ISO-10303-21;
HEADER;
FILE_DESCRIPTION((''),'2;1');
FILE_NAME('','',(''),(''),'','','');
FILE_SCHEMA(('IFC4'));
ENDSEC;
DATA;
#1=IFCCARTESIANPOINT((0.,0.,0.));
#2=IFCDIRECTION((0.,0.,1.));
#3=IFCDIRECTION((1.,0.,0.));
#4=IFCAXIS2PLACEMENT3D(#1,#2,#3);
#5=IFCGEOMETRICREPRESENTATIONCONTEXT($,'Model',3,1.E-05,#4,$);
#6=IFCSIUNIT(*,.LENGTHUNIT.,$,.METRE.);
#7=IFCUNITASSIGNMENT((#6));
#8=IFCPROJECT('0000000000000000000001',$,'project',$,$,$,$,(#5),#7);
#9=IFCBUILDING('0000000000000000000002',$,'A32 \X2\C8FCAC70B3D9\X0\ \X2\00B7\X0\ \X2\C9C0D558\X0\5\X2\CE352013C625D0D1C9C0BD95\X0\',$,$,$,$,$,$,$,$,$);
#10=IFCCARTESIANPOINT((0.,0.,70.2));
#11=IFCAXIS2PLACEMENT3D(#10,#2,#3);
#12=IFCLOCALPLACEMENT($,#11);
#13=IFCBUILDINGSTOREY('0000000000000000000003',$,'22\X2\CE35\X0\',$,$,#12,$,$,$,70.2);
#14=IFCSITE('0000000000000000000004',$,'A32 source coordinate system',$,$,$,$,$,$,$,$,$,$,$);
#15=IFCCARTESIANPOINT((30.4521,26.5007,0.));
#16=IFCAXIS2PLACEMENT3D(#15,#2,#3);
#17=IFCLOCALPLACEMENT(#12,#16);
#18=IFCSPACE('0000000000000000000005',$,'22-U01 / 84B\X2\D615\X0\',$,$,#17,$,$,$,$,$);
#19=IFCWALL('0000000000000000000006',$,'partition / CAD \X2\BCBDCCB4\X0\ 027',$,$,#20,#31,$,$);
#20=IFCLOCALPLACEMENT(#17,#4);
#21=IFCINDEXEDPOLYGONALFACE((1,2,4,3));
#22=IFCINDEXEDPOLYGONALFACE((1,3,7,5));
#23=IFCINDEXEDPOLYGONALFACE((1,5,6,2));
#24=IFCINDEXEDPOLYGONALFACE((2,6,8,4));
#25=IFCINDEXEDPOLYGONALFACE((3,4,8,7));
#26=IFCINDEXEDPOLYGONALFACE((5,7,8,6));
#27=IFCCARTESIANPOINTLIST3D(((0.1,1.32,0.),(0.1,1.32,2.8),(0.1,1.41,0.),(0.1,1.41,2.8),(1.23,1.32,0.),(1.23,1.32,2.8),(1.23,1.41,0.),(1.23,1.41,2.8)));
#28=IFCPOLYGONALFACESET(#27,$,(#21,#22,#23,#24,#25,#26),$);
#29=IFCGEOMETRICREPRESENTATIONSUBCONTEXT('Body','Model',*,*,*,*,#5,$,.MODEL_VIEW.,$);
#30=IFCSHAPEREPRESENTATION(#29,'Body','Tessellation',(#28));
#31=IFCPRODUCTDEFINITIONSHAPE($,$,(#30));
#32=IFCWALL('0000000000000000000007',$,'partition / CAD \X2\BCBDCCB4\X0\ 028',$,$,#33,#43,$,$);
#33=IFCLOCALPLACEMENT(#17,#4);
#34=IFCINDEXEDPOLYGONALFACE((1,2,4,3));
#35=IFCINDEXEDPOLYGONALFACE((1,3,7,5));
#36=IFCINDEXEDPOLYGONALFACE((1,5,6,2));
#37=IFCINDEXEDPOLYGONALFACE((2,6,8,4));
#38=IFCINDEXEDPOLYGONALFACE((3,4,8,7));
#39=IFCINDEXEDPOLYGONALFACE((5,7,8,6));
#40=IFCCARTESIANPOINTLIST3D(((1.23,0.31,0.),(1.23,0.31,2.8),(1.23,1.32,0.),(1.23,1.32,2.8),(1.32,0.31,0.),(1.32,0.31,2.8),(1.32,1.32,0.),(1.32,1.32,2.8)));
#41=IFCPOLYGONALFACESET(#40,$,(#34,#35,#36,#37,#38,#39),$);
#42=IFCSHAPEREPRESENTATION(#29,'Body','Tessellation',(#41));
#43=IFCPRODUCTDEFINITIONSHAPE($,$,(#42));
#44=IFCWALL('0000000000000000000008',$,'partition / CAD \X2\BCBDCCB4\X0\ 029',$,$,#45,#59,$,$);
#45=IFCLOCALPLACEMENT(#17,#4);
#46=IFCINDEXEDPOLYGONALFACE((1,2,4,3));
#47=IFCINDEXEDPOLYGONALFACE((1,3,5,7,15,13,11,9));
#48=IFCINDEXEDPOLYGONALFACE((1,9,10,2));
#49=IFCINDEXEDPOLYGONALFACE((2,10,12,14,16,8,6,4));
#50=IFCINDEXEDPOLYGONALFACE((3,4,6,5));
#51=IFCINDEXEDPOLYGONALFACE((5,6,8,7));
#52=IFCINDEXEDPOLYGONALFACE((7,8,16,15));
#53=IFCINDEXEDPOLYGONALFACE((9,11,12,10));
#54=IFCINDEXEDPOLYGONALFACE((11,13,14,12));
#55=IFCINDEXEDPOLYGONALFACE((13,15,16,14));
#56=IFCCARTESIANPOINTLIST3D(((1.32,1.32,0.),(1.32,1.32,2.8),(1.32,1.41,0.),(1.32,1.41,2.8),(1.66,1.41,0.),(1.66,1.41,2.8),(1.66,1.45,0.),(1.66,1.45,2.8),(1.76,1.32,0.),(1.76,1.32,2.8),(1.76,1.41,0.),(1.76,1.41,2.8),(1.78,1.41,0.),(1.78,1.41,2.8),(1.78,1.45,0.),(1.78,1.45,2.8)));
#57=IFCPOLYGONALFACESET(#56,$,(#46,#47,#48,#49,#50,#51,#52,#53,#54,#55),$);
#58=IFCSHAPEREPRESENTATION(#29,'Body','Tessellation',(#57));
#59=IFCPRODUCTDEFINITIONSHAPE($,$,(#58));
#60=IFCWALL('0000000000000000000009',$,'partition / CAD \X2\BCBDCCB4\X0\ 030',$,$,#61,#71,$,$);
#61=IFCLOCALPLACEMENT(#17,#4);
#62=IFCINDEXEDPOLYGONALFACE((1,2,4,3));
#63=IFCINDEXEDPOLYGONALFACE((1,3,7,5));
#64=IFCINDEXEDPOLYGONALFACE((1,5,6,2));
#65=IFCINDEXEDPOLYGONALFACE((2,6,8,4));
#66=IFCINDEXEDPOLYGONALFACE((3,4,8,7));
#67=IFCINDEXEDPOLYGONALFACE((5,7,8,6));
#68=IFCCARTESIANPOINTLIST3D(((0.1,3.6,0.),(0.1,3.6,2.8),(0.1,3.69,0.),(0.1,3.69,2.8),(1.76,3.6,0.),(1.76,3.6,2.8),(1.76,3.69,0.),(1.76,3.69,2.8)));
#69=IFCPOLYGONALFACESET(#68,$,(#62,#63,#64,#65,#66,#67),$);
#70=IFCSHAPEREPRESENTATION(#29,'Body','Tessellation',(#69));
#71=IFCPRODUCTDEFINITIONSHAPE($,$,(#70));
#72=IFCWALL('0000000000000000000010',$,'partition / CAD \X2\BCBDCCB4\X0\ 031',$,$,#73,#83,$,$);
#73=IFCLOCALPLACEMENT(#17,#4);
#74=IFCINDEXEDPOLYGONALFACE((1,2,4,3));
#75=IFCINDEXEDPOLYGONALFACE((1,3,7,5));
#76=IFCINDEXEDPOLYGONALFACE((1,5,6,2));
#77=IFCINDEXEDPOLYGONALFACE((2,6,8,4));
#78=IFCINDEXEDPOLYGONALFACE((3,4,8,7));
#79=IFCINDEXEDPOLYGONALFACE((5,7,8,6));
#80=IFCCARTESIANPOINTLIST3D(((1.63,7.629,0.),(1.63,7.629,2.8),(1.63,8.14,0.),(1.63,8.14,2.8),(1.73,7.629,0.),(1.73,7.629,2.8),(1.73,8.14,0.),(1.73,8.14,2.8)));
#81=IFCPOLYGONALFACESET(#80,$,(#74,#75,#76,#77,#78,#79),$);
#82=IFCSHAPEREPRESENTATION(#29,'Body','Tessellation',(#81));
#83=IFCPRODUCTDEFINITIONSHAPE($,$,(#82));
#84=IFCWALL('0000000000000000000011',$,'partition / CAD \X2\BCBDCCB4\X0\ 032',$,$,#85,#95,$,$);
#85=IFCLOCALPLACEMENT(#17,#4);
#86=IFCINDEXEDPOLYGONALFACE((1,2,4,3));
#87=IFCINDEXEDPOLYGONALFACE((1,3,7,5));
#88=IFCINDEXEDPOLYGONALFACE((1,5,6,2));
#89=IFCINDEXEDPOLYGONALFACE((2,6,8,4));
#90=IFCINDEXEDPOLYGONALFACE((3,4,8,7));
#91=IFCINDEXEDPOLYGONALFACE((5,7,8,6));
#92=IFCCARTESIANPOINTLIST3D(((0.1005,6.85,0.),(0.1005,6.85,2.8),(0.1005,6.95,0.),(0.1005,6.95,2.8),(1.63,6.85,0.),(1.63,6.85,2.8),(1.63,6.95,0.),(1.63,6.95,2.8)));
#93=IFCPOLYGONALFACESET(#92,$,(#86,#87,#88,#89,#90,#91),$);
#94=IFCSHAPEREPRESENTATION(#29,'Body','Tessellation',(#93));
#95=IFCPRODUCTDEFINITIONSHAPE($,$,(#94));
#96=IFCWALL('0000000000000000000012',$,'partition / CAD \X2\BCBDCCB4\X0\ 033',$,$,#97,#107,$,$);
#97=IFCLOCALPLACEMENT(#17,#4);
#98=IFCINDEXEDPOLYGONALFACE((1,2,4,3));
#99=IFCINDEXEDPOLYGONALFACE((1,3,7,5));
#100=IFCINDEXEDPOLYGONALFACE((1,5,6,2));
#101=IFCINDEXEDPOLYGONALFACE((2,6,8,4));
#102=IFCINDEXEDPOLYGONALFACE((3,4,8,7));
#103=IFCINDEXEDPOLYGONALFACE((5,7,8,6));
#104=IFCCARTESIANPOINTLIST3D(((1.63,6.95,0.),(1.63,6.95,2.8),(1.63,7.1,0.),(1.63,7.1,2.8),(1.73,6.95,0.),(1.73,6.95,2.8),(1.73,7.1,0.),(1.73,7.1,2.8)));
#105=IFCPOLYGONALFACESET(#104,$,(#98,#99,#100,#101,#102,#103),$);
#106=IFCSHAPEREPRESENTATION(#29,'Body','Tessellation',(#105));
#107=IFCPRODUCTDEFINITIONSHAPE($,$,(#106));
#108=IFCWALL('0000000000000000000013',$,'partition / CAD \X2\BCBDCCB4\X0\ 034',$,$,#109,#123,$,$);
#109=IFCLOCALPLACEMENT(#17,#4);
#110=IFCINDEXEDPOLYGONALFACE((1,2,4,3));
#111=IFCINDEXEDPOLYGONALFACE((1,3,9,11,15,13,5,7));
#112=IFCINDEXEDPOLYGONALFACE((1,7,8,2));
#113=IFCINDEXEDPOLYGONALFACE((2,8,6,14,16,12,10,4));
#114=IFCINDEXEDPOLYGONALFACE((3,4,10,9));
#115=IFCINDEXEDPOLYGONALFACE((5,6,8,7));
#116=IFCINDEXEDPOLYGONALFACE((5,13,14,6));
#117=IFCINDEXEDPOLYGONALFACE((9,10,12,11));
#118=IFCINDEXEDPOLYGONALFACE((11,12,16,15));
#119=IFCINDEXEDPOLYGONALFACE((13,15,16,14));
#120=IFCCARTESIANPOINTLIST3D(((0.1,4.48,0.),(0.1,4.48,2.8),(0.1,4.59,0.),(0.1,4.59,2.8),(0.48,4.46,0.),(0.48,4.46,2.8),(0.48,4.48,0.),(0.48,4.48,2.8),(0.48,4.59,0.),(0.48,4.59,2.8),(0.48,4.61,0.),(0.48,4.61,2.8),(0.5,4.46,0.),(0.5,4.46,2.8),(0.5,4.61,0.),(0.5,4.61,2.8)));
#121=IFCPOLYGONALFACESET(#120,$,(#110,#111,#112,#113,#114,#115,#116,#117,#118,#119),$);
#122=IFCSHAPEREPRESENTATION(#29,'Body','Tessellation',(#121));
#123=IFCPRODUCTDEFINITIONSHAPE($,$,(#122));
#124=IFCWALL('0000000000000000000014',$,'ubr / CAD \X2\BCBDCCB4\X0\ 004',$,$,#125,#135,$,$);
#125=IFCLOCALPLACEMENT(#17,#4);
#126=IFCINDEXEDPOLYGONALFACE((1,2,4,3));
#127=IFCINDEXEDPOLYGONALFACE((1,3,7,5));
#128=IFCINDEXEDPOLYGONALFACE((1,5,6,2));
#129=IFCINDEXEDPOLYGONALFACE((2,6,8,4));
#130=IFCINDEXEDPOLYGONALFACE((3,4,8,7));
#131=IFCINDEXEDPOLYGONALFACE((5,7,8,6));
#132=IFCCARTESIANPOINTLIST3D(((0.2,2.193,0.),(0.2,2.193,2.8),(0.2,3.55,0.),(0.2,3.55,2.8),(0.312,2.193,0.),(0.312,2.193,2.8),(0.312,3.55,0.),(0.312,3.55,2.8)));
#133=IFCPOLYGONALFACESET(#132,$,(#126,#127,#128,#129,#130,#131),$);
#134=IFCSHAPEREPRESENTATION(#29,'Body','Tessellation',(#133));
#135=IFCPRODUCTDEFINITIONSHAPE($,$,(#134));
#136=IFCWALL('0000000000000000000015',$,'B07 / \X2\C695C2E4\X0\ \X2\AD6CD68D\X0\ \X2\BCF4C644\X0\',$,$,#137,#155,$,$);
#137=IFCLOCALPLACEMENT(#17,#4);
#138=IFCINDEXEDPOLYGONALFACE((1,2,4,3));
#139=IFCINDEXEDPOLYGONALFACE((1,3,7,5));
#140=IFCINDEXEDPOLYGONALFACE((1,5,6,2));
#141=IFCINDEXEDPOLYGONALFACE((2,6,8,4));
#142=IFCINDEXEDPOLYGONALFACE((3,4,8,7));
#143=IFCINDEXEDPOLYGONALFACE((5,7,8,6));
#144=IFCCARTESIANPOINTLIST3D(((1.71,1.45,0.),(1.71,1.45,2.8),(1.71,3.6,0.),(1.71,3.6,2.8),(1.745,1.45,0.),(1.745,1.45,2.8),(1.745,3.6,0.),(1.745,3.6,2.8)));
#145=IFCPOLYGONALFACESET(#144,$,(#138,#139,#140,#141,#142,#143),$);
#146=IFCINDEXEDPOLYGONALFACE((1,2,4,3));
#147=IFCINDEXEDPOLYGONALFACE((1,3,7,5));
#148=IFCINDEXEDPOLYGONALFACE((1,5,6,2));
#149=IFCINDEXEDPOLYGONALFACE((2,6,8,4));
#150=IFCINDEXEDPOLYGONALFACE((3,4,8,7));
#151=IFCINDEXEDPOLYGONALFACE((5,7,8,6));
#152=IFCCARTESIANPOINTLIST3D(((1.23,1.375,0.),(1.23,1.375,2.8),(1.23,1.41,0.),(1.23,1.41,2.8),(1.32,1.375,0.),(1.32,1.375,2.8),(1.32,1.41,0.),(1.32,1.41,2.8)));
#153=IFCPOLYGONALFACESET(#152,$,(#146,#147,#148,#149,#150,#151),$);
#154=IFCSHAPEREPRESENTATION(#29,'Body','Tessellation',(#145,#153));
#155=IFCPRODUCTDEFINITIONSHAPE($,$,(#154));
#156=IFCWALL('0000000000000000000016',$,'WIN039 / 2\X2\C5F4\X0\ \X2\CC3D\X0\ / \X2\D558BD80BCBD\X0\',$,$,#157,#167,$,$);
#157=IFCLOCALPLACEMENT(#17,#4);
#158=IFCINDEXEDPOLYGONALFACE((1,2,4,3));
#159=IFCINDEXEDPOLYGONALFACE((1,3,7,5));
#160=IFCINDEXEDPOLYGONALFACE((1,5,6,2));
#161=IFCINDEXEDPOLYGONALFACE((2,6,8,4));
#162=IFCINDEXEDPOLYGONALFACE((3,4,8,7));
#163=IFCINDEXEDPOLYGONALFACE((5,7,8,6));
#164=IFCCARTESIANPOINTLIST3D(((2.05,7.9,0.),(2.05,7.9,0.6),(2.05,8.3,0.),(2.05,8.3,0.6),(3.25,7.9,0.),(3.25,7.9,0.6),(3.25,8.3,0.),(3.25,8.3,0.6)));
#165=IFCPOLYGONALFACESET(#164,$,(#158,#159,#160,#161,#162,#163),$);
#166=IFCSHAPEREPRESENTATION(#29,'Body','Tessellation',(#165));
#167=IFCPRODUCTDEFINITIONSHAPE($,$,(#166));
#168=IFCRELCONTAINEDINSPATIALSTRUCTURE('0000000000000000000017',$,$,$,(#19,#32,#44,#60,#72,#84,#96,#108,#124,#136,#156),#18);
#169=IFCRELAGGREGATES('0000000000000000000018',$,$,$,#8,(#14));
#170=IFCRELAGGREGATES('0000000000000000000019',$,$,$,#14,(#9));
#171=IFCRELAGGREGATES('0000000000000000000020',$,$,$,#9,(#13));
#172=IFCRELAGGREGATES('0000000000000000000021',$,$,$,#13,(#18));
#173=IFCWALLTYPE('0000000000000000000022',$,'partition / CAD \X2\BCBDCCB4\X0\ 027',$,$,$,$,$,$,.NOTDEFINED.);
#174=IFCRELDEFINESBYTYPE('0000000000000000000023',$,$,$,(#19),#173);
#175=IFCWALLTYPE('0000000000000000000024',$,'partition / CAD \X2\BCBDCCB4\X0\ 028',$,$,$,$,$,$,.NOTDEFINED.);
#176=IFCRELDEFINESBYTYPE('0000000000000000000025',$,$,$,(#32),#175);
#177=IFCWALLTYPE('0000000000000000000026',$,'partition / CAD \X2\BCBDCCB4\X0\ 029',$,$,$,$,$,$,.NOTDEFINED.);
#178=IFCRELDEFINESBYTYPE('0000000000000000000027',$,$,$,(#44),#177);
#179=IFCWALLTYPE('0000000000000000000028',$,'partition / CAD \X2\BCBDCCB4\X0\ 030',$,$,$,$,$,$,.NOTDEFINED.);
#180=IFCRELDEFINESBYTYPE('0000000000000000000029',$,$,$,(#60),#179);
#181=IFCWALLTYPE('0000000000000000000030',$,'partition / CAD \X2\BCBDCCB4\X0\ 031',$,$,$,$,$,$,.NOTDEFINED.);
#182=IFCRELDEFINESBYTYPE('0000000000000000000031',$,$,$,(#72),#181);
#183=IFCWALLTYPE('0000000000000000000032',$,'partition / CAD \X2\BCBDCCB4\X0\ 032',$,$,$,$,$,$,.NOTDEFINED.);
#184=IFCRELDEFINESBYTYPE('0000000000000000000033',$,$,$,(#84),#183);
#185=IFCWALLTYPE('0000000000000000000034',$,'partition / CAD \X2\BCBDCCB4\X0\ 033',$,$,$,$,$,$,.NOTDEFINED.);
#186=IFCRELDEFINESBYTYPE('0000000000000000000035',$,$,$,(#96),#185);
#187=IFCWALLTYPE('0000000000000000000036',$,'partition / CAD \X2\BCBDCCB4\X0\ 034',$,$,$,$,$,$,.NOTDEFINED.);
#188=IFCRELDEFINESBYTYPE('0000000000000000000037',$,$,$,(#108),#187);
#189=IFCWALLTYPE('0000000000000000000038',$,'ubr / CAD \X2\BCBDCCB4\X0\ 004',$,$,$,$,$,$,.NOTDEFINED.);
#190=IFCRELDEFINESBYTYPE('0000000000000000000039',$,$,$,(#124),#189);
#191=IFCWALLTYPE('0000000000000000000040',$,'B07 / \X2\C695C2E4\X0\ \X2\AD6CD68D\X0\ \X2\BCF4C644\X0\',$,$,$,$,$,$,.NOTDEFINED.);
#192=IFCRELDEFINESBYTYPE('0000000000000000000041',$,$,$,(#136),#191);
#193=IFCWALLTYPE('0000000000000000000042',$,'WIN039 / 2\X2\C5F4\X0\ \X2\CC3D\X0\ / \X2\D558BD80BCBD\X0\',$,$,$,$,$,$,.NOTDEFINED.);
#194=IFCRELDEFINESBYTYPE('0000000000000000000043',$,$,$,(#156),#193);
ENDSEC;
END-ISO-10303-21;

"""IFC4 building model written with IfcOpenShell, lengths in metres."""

from ifc_helpers import new_model, si_unit, frame, origin, origin_with_axes, place, context, subcontext, project, spatial, polyline, outline, extrude, source, transform, mapped, type_object, type_shapes, element, save


model = new_model("IFC4")

# Units and contexts
model_context = context("Model", 3, precision=1e-05, world=origin_with_axes())
body_context = subcontext(model_context, "Body", "Model", "MODEL_VIEW")
ifc_project = project(units=[si_unit("LENGTHUNIT", "METRE")], contexts=[model_context])

# Site, building, storey, space
site = spatial("IfcSite", under=ifc_project, Name="A32 source coordinate system")
building = spatial("IfcBuilding", under=site, Name="A32 주거동 · 지하5층–옥탑지붕")
storey_placement = place(None, frame((0.0, 0.0, 70.2), z_axis=(0.0, 0.0, 1.0), x_axis=(1.0, 0.0, 0.0)))
storey = spatial("IfcBuildingStorey", under=building, at=storey_placement, Name="22층", Elevation=70.2)
space_placement = place(storey_placement, frame((30.4521, 26.5007, 0.0), z_axis=(0.0, 0.0, 1.0), x_axis=(1.0, 0.0, 0.0)))
space = spatial("IfcSpace", under=storey, at=space_placement, Name="22-U01 / 84B형")

# Walls
wall_type_1 = type_object("IfcWallType", Name="partition / CAD 벽체 027", PredefinedType="NOTDEFINED")
shared_shape_1 = source(origin(), body_context, "Body", "SweptSolid", [
    extrude(outline(polyline([(0.1, 1.32), (0.1, 1.41), (1.23, 1.41), (1.23, 1.32), (0.1, 1.32)])), origin(), (0.0, 0.0, 1.0), 2.8),
])
type_shapes(wall_type_1, [shared_shape_1])
wall_1_placement = place(space_placement, origin_with_axes())
element("IfcWall", 1, at=wall_1_placement, inside=space, type_object=wall_type_1, Name="partition / CAD 벽체 027", context=body_context, shape_type="MappedRepresentation", body=[
    mapped(shared_shape_1, transform((0.0, 0.0, 0.0), scale=1.0)),
])
wall_type_2 = type_object("IfcWallType", Name="partition / CAD 벽체 028", PredefinedType="NOTDEFINED")
shared_shape_2 = source(origin(), body_context, "Body", "SweptSolid", [
    extrude(outline(polyline([(1.32, 0.31), (1.23, 0.31), (1.23, 1.32), (1.32, 1.32), (1.32, 0.31)])), origin(), (0.0, 0.0, 1.0), 2.8),
])
type_shapes(wall_type_2, [shared_shape_2])
wall_2_placement = place(space_placement, origin_with_axes())
element("IfcWall", 2, at=wall_2_placement, inside=space, type_object=wall_type_2, Name="partition / CAD 벽체 028", context=body_context, shape_type="MappedRepresentation", body=[
    mapped(shared_shape_2, transform((0.0, 0.0, 0.0), scale=1.0)),
])
wall_type_3 = type_object("IfcWallType", Name="partition / CAD 벽체 029", PredefinedType="NOTDEFINED")
shared_shape_3 = source(origin(), body_context, "Body", "SweptSolid", [
    extrude(outline(polyline([(1.66, 1.41), (1.66, 1.45), (1.78, 1.45), (1.78, 1.41), (1.76, 1.41), (1.76, 1.32), (1.32, 1.32), (1.32, 1.41), (1.66, 1.41)])), origin(), (0.0, 0.0, 1.0), 2.8),
])
type_shapes(wall_type_3, [shared_shape_3])
wall_3_placement = place(space_placement, origin_with_axes())
element("IfcWall", 3, at=wall_3_placement, inside=space, type_object=wall_type_3, Name="partition / CAD 벽체 029", context=body_context, shape_type="MappedRepresentation", body=[
    mapped(shared_shape_3, transform((0.0, 0.0, 0.0), scale=1.0)),
])
wall_type_4 = type_object("IfcWallType", Name="partition / CAD 벽체 030", PredefinedType="NOTDEFINED")
shared_shape_4 = source(origin(), body_context, "Body", "SweptSolid", [
    extrude(outline(polyline([(1.76, 3.69), (1.76, 3.6), (0.1, 3.6), (0.1, 3.69), (1.76, 3.69)])), origin(), (0.0, 0.0, 1.0), 2.8),
])
type_shapes(wall_type_4, [shared_shape_4])
wall_4_placement = place(space_placement, origin_with_axes())
element("IfcWall", 4, at=wall_4_placement, inside=space, type_object=wall_type_4, Name="partition / CAD 벽체 030", context=body_context, shape_type="MappedRepresentation", body=[
    mapped(shared_shape_4, transform((0.0, 0.0, 0.0), scale=1.0)),
])
wall_type_5 = type_object("IfcWallType", Name="partition / CAD 벽체 031", PredefinedType="NOTDEFINED")
shared_shape_5 = source(origin(), body_context, "Body", "SweptSolid", [
    extrude(outline(polyline([(1.63, 8.14), (1.73, 8.14), (1.73, 7.629), (1.63, 7.629), (1.63, 8.14)])), origin(), (0.0, 0.0, 1.0), 2.8),
])
type_shapes(wall_type_5, [shared_shape_5])
wall_5_placement = place(space_placement, origin_with_axes())
element("IfcWall", 5, at=wall_5_placement, inside=space, type_object=wall_type_5, Name="partition / CAD 벽체 031", context=body_context, shape_type="MappedRepresentation", body=[
    mapped(shared_shape_5, transform((0.0, 0.0, 0.0), scale=1.0)),
])
wall_type_6 = type_object("IfcWallType", Name="partition / CAD 벽체 032", PredefinedType="NOTDEFINED")
shared_shape_6 = source(origin(), body_context, "Body", "SweptSolid", [
    extrude(outline(polyline([(0.1005, 6.95), (1.63, 6.95), (1.63, 6.85), (0.1005, 6.85), (0.1005, 6.95)])), origin(), (0.0, 0.0, 1.0), 2.8),
])
type_shapes(wall_type_6, [shared_shape_6])
wall_6_placement = place(space_placement, origin_with_axes())
element("IfcWall", 6, at=wall_6_placement, inside=space, type_object=wall_type_6, Name="partition / CAD 벽체 032", context=body_context, shape_type="MappedRepresentation", body=[
    mapped(shared_shape_6, transform((0.0, 0.0, 0.0), scale=1.0)),
])
wall_type_7 = type_object("IfcWallType", Name="partition / CAD 벽체 033", PredefinedType="NOTDEFINED")
shared_shape_7 = source(origin(), body_context, "Body", "SweptSolid", [
    extrude(outline(polyline([(1.63, 7.1), (1.73, 7.1), (1.73, 6.95), (1.63, 6.95), (1.63, 7.1)])), origin(), (0.0, 0.0, 1.0), 2.8),
])
type_shapes(wall_type_7, [shared_shape_7])
wall_7_placement = place(space_placement, origin_with_axes())
element("IfcWall", 7, at=wall_7_placement, inside=space, type_object=wall_type_7, Name="partition / CAD 벽체 033", context=body_context, shape_type="MappedRepresentation", body=[
    mapped(shared_shape_7, transform((0.0, 0.0, 0.0), scale=1.0)),
])
wall_type_8 = type_object("IfcWallType", Name="partition / CAD 벽체 034", PredefinedType="NOTDEFINED")
shared_shape_8 = source(origin(), body_context, "Body", "SweptSolid", [
    extrude(outline(polyline([(0.48, 4.61), (0.5, 4.61), (0.5, 4.46), (0.48, 4.46), (0.48, 4.48), (0.1, 4.48), (0.1, 4.59), (0.48, 4.59), (0.48, 4.61)])), origin(), (0.0, 0.0, 1.0), 2.8),
])
type_shapes(wall_type_8, [shared_shape_8])
wall_8_placement = place(space_placement, origin_with_axes())
element("IfcWall", 8, at=wall_8_placement, inside=space, type_object=wall_type_8, Name="partition / CAD 벽체 034", context=body_context, shape_type="MappedRepresentation", body=[
    mapped(shared_shape_8, transform((0.0, 0.0, 0.0), scale=1.0)),
])
wall_type_9 = type_object("IfcWallType", Name="ubr / CAD 벽체 004", PredefinedType="NOTDEFINED")
shared_shape_9 = source(origin(), body_context, "Body", "SweptSolid", [
    extrude(outline(polyline([(0.312, 2.193), (0.2, 2.193), (0.2, 3.55), (0.312, 3.55), (0.312, 2.193)])), origin(), (0.0, 0.0, 1.0), 2.8),
])
type_shapes(wall_type_9, [shared_shape_9])
wall_9_placement = place(space_placement, origin_with_axes())
element("IfcWall", 9, at=wall_9_placement, inside=space, type_object=wall_type_9, Name="ubr / CAD 벽체 004", context=body_context, shape_type="MappedRepresentation", body=[
    mapped(shared_shape_9, transform((0.0, 0.0, 0.0), scale=1.0)),
])
wall_type_10 = type_object("IfcWallType", Name="B07 / 욕실 구획 보완", PredefinedType="NOTDEFINED")
shared_shape_10 = source(origin(), body_context, "Body", "SweptSolid", [
    extrude(outline(polyline([(1.71, 1.45), (1.71, 3.6), (1.745, 3.6), (1.745, 1.45), (1.71, 1.45)])), origin(), (0.0, 0.0, 1.0), 2.8),
    extrude(outline(polyline([(1.32, 1.41), (1.32, 1.375), (1.23, 1.375), (1.23, 1.41), (1.32, 1.41)])), origin(), (0.0, 0.0, 1.0), 2.8),
])
type_shapes(wall_type_10, [shared_shape_10])
wall_10_placement = place(space_placement, origin_with_axes())
element("IfcWall", 10, at=wall_10_placement, inside=space, type_object=wall_type_10, Name="B07 / 욕실 구획 보완", context=body_context, shape_type="MappedRepresentation", body=[
    mapped(shared_shape_10, transform((0.0, 0.0, 0.0), scale=1.0)),
])
wall_type_11 = type_object("IfcWallType", Name="WIN039 / 2열 창 / 하부벽", PredefinedType="NOTDEFINED")
shared_shape_11 = source(origin(), body_context, "Body", "SweptSolid", [
    extrude(outline(polyline([(2.05, 8.3), (3.25, 8.3), (3.25, 7.9), (2.05, 7.9), (2.05, 8.3)])), origin(), (0.0, 0.0, 1.0), 0.6),
])
type_shapes(wall_type_11, [shared_shape_11])
wall_11_placement = place(space_placement, origin_with_axes())
element("IfcWall", 11, at=wall_11_placement, inside=space, type_object=wall_type_11, Name="WIN039 / 2열 창 / 하부벽", context=body_context, shape_type="MappedRepresentation", body=[
    mapped(shared_shape_11, transform((0.0, 0.0, 0.0), scale=1.0)),
])

save(model, "model.ifc")
